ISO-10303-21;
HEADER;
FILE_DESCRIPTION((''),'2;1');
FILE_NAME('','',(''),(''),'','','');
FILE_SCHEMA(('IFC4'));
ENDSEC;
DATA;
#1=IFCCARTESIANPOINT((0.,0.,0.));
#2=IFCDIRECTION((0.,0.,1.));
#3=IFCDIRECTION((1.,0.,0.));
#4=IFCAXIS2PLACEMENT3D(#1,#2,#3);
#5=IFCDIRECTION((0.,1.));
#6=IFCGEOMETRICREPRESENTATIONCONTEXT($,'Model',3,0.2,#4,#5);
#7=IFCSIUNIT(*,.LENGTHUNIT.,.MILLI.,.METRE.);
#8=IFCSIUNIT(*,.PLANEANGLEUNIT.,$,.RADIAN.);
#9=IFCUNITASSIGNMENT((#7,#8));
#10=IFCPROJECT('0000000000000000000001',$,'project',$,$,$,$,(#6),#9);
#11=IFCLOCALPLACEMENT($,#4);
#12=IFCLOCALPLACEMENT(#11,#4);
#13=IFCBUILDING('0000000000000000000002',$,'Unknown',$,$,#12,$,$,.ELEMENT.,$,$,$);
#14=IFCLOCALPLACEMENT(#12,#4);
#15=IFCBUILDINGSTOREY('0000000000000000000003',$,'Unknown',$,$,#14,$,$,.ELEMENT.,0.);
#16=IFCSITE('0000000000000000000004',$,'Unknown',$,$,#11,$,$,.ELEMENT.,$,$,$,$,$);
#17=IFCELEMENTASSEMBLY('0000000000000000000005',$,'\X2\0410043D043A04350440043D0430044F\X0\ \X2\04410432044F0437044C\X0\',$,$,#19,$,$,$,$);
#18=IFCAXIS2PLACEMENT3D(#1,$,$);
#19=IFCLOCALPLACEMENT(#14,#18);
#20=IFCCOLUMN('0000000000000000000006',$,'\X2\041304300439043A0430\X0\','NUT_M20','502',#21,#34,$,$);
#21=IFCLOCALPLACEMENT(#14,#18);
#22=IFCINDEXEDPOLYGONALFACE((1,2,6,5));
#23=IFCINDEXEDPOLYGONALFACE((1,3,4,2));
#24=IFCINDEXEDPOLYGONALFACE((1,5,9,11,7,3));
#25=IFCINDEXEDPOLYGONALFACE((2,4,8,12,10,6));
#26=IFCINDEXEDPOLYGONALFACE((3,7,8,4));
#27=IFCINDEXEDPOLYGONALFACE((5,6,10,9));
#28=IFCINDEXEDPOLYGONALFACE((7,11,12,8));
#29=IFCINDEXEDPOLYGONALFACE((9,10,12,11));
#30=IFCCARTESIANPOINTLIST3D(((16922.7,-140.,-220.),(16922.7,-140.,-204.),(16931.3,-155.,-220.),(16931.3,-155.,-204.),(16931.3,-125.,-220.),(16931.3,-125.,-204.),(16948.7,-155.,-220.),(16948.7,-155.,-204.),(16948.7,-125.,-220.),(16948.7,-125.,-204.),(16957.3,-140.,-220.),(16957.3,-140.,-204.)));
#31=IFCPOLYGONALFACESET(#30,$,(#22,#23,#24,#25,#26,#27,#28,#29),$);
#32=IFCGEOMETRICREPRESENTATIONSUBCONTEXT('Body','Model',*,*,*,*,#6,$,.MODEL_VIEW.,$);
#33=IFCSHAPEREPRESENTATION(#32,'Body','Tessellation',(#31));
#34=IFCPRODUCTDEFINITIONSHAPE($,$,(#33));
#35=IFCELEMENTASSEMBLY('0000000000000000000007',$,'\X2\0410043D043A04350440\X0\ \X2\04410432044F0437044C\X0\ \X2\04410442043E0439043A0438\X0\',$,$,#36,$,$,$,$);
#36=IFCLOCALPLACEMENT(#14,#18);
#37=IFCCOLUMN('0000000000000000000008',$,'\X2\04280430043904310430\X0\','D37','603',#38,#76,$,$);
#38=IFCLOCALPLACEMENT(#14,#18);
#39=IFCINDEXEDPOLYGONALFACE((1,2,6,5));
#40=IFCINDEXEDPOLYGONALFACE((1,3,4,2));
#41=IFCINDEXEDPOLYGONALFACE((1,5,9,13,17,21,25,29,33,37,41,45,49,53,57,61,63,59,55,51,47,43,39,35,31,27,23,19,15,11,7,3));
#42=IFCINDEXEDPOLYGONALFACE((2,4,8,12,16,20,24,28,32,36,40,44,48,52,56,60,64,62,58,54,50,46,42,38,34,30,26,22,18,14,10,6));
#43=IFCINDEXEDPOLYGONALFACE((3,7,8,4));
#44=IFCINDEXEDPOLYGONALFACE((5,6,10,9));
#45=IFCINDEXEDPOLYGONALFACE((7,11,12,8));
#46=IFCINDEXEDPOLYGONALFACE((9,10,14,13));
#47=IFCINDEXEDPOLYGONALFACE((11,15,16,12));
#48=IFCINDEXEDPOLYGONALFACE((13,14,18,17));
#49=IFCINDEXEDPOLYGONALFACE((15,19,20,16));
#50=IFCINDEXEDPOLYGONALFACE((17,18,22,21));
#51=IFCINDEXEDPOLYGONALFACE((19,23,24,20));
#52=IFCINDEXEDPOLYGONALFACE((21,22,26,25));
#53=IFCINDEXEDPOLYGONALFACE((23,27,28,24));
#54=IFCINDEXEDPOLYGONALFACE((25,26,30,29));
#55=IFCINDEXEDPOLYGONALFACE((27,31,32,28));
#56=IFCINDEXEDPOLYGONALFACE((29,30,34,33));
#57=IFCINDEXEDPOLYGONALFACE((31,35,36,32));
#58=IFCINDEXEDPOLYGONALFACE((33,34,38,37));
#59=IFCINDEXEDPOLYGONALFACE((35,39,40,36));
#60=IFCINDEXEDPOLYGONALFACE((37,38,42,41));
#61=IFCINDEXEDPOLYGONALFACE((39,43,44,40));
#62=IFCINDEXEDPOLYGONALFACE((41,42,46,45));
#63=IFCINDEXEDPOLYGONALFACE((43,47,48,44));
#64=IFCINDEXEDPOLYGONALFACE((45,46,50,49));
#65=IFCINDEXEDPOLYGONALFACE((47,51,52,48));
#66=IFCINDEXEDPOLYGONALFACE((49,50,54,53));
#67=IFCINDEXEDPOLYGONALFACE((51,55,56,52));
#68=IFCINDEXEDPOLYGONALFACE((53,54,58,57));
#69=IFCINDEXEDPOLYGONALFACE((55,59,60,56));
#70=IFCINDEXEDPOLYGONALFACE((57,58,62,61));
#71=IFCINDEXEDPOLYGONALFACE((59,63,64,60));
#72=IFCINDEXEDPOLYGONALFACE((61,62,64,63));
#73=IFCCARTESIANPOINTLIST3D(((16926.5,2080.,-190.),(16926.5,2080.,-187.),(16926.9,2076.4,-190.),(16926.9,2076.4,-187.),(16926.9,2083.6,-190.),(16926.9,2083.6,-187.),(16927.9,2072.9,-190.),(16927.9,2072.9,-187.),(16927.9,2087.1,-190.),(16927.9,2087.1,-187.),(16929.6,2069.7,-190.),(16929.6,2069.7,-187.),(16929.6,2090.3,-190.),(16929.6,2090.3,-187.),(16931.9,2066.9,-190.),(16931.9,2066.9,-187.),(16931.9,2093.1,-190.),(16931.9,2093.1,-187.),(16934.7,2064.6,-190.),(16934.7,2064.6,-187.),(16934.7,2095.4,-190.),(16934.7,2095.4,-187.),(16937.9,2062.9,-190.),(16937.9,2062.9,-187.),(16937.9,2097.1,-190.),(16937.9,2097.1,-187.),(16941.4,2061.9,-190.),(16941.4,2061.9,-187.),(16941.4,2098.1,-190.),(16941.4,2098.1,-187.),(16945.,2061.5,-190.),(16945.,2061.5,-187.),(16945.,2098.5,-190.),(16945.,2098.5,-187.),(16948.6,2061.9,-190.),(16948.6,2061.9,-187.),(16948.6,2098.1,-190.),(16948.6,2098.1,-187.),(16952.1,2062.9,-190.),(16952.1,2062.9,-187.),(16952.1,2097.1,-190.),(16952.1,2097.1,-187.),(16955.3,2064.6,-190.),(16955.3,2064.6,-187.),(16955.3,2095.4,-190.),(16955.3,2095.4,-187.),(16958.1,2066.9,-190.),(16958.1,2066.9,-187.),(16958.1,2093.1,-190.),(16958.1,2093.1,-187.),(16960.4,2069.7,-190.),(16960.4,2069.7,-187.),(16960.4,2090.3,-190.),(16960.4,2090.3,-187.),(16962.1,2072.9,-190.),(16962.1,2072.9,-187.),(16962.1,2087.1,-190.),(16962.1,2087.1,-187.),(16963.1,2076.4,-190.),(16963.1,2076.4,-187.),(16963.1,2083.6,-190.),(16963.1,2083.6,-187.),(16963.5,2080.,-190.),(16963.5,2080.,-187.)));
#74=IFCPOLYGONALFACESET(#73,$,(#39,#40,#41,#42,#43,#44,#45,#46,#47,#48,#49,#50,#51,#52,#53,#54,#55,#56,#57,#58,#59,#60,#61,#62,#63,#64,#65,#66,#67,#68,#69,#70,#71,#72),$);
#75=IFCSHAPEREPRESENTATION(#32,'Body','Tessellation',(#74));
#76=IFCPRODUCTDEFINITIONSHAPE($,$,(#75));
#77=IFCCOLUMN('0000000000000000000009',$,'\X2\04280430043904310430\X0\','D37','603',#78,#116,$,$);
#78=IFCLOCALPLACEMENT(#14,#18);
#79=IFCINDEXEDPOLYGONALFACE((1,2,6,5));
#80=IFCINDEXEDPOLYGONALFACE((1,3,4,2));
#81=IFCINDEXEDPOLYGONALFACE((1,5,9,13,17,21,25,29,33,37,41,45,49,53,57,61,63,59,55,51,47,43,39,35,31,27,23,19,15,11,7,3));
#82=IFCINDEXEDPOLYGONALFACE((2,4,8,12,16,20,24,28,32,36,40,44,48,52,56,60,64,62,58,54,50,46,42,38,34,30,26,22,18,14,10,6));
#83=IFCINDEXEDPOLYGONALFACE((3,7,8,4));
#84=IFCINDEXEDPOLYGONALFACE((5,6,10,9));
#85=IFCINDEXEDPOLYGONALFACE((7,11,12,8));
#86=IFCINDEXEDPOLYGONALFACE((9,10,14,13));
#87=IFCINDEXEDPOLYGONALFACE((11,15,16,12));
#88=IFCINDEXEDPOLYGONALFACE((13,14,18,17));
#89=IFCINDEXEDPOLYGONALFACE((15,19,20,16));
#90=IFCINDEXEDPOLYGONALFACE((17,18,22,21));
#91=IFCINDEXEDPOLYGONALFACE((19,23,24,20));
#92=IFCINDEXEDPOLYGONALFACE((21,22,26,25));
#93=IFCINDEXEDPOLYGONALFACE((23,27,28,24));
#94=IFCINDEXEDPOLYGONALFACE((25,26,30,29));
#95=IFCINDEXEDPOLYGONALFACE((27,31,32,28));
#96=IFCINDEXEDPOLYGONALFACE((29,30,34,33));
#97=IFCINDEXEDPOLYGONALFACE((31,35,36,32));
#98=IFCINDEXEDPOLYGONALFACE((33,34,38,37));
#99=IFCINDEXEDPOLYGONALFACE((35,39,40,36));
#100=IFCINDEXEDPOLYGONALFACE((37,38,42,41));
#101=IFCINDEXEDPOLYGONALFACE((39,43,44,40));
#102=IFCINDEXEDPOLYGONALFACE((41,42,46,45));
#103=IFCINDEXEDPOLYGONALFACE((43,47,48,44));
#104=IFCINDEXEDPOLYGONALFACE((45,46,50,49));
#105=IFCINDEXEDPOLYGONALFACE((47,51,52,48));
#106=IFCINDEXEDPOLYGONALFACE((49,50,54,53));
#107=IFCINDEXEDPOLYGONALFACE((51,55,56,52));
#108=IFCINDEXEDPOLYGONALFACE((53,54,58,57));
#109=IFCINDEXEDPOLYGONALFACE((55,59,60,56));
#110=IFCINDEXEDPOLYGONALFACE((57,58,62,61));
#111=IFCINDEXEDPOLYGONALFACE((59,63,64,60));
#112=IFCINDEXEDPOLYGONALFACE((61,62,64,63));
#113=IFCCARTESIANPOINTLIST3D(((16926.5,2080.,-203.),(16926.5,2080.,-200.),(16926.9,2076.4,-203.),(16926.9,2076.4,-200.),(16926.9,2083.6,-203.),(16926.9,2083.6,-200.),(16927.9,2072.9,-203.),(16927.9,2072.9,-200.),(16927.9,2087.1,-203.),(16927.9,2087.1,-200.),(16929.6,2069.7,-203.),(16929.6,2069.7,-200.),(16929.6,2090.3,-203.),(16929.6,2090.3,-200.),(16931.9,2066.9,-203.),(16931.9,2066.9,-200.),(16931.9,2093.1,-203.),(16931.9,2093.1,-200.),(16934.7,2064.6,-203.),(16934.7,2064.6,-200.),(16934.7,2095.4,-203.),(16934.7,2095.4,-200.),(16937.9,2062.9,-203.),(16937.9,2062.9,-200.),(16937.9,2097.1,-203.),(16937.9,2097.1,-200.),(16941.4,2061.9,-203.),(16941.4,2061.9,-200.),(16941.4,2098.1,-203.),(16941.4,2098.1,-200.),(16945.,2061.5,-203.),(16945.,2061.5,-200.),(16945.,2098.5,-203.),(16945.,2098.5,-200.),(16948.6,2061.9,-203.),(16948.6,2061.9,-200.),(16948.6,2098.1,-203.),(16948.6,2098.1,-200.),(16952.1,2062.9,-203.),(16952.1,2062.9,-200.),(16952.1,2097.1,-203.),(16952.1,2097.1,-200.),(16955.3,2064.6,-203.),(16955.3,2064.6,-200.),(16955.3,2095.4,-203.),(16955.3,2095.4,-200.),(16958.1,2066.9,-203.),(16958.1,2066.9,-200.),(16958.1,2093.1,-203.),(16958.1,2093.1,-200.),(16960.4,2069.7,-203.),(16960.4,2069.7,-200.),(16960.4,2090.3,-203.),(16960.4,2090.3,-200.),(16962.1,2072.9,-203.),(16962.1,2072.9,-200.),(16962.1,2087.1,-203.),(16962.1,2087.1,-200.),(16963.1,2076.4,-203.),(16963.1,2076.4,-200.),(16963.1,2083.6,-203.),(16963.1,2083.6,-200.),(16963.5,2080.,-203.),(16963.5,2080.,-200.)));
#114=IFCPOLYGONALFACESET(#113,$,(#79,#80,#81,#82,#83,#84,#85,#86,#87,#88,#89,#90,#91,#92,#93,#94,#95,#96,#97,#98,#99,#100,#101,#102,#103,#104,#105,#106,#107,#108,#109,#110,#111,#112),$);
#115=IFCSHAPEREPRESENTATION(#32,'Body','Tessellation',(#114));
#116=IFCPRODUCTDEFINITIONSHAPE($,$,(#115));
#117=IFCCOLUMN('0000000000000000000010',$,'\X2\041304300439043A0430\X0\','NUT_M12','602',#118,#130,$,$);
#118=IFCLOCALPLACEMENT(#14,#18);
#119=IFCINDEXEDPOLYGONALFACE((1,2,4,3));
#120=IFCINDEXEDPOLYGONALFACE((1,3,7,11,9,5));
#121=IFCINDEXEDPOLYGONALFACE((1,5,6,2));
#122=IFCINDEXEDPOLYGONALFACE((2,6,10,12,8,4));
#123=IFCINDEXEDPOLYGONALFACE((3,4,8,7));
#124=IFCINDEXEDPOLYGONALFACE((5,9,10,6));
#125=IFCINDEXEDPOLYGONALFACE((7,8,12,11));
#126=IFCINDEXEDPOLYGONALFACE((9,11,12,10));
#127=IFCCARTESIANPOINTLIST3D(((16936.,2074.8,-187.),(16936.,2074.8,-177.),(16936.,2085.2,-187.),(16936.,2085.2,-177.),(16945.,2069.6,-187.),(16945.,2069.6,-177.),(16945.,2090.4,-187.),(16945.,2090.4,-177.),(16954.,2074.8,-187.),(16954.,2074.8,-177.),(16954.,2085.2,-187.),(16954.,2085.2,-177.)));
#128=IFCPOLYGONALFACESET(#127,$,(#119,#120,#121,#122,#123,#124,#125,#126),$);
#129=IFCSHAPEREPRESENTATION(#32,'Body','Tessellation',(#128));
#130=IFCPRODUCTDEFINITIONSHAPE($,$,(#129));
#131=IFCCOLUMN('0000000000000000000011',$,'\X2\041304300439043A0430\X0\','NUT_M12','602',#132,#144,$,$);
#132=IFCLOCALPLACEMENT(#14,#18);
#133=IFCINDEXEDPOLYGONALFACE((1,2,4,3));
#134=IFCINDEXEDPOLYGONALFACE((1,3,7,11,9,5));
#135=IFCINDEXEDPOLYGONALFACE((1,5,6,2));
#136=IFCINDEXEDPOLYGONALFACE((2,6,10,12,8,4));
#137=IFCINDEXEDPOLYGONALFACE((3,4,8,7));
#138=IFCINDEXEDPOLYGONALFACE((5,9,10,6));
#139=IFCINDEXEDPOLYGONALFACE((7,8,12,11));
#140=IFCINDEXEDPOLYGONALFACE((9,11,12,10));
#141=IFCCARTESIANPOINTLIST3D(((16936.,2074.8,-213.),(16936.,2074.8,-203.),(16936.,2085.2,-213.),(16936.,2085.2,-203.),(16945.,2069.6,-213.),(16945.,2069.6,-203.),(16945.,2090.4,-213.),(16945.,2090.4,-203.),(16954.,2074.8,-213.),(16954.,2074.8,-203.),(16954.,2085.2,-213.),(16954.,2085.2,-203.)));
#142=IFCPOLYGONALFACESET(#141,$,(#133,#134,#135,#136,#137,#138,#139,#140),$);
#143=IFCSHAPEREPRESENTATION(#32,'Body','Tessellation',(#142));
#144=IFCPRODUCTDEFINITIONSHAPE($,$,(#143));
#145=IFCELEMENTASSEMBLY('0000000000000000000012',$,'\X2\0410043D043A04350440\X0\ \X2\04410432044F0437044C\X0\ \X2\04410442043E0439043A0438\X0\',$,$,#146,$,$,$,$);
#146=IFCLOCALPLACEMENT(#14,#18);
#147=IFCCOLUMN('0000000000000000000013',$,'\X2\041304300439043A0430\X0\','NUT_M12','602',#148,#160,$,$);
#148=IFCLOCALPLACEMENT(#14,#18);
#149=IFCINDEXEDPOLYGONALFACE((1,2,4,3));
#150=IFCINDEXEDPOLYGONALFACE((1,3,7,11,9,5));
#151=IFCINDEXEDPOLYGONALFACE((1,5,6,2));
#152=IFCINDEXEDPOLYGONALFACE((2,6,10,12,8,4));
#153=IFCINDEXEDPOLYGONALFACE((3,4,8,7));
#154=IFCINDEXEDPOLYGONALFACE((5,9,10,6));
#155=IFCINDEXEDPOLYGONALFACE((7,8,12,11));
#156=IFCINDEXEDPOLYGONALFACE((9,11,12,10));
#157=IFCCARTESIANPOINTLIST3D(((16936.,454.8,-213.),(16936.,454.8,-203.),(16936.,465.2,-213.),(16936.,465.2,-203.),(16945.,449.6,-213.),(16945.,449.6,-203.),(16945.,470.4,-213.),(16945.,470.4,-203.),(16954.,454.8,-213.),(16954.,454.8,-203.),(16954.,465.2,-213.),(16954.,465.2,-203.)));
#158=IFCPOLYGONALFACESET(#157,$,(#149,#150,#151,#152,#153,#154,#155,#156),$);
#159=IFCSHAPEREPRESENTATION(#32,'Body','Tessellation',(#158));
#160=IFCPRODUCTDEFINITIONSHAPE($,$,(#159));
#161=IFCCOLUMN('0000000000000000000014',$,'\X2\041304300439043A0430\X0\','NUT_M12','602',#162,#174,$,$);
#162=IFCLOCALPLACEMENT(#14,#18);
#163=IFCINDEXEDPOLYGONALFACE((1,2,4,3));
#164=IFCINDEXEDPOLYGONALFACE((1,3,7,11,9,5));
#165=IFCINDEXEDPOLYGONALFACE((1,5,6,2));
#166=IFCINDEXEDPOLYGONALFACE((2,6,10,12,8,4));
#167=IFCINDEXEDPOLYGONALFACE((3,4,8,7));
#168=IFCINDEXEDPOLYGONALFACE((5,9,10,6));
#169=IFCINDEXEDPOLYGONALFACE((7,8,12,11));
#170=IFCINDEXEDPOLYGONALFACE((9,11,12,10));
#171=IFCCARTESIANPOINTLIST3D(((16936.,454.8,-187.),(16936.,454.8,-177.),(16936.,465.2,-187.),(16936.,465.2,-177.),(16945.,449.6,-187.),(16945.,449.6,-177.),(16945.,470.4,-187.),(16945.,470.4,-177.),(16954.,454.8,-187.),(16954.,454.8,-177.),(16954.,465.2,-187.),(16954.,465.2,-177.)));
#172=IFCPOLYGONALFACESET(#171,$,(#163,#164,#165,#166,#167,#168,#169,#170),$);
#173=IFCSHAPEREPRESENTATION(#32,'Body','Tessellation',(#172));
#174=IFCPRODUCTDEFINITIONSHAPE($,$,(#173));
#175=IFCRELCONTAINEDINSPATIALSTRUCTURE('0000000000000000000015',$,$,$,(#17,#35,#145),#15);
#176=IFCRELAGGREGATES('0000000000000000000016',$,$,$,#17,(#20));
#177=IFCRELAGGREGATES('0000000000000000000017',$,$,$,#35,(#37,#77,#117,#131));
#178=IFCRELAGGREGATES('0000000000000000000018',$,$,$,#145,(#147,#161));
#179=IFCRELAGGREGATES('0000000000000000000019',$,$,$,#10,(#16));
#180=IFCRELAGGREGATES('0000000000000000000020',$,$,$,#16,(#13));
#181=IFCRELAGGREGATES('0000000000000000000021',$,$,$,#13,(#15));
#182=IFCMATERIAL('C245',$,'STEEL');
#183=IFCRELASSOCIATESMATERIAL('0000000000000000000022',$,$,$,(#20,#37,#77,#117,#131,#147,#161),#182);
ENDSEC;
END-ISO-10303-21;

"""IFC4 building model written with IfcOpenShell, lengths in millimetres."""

from ifc_helpers import new_model, si_unit, direction, frame, origin_with_axes, place, context, subcontext, project, spatial, line, indexed_curve, outline, extrude, material, element, aggregate, save


model = new_model("IFC4")

# Units and contexts
model_context = context("Model", 3, precision=0.2, world=origin_with_axes(), true_north=direction((0.0, 1.0)))
body_context = subcontext(model_context, "Body", "Model", "MODEL_VIEW")
ifc_project = project(units=[si_unit("LENGTHUNIT", "METRE", prefix="MILLI"), si_unit("PLANEANGLEUNIT", "RADIAN")], contexts=[model_context])

# Site, building, storey
site_placement = place(None, origin_with_axes())
site = spatial("IfcSite", under=ifc_project, at=site_placement, Name="Unknown", CompositionType="ELEMENT")
building_placement = place(site_placement, origin_with_axes())
building = spatial("IfcBuilding", under=site, at=building_placement, Name="Unknown", CompositionType="ELEMENT")
storey_placement = place(building_placement, origin_with_axes())
storey = spatial("IfcBuildingStorey", under=building, at=storey_placement, Name="Unknown", CompositionType="ELEMENT", Elevation=0.0)

# Element assemblies, columns
ifc_material_1 = material(Name="C245", Category="STEEL")
assembly_1_placement = place(storey_placement, frame((16940.0, -140.0, -125.0), z_axis=(1.0, 0.0, 0.0), x_axis=(0.0, 0.0, -1.0)))
assembly_1 = element("IfcElementAssembly", 1, at=assembly_1_placement, inside=storey, Name="Анкерная связь")
column_1_placement = place(assembly_1_placement, frame((79.0, 0.0, 0.0), z_axis=(0.0, 0.0, 1.0), x_axis=(1.0, 0.0, 0.0)))
column_1 = element("IfcColumn", 2, at=column_1_placement, material=ifc_material_1, Name="Гайка", Description="NUT_M20", ObjectType="502", context=body_context, shape_type="SolidModel", body=[
    extrude(outline(indexed_curve([(8.7, -15.0), (17.3, 0.0), (8.7, 15.0), (-8.7, 15.0), (-17.3, 0.0), (-8.7, -15.0)], segments=[line(1, 2, 3, 4, 5, 6, 1)])), frame((0.0, 0.0, 0.0), z_axis=(-1.0, 0.0, 0.0), x_axis=(0.0, 0.0, 1.0)), (0.0, 0.0, -1.0), 16.0),
])
assembly_2_placement = place(storey_placement, frame((16945.0, 2080.0, -160.0), z_axis=(0.0, -1.0, 0.0), x_axis=(0.0, 0.0, -1.0)))
assembly_2 = element("IfcElementAssembly", 3, at=assembly_2_placement, inside=storey, Name="Анкер связь стойки")
column_2_placement = place(assembly_2_placement, frame((27.0, 0.0, 0.0), z_axis=(0.0, 0.0, 1.0), x_axis=(1.0, 0.0, 0.0)))
column_2 = element("IfcColumn", 4, at=column_2_placement, material=ifc_material_1, Name="Шайба", Description="D37", ObjectType="603", context=body_context, shape_type="SolidModel", body=[
    extrude(outline(indexed_curve([(18.5, 0.0), (18.1, 3.6), (17.1, 7.1), (15.4, 10.3), (13.1, 13.1), (10.3, 15.4), (7.1, 17.1), (3.6, 18.1), (0.0, 18.5), (-3.6, 18.1), (-7.1, 17.1), (-10.3, 15.4), (-13.1, 13.1), (-15.4, 10.3), (-17.1, 7.1), (-18.1, 3.6), (-18.5, 0.0), (-18.1, -3.6), (-17.1, -7.1), (-15.4, -10.3), (-13.1, -13.1), (-10.3, -15.4), (-7.1, -17.1), (-3.6, -18.1), (0.0, -18.5), (3.6, -18.1), (7.1, -17.1), (10.3, -15.4), (13.1, -13.1), (15.4, -10.3), (17.1, -7.1), (18.1, -3.6)], segments=[line(1, 2, 3, 4, 5, 6, 7, 8, 9, 10, 11, 12, 13, 14, 15, 16, 17, 18, 19, 20, 21, 22, 23, 24, 25, 26, 27, 28, 29, 30, 31, 32, 1)])), frame((0.0, 0.0, 0.0), z_axis=(-1.0, 0.0, 0.0), x_axis=(0.0, 0.0, 1.0)), (0.0, 0.0, -1.0), 3.0),
])
column_3_placement = place(assembly_2_placement, frame((40.0, 0.0, 0.0), z_axis=(0.0, -1.0, 0.0), x_axis=(1.0, 0.0, 0.0)))
column_3 = element("IfcColumn", 5, at=column_3_placement, material=ifc_material_1, Name="Шайба", Description="D37", ObjectType="603", context=body_context, shape_type="SolidModel", body=[
    extrude(outline(indexed_curve([(18.5, 0.0), (18.1, 3.6), (17.1, 7.1), (15.4, 10.3), (13.1, 13.1), (10.3, 15.4), (7.1, 17.1), (3.6, 18.1), (0.0, 18.5), (-3.6, 18.1), (-7.1, 17.1), (-10.3, 15.4), (-13.1, 13.1), (-15.4, 10.3), (-17.1, 7.1), (-18.1, 3.6), (-18.5, 0.0), (-18.1, -3.6), (-17.1, -7.1), (-15.4, -10.3), (-13.1, -13.1), (-10.3, -15.4), (-7.1, -17.1), (-3.6, -18.1), (0.0, -18.5), (3.6, -18.1), (7.1, -17.1), (10.3, -15.4), (13.1, -13.1), (15.4, -10.3), (17.1, -7.1), (18.1, -3.6)], segments=[line(1, 2, 3, 4, 5, 6, 7, 8, 9, 10, 11, 12, 13, 14, 15, 16, 17, 18, 19, 20, 21, 22, 23, 24, 25, 26, 27, 28, 29, 30, 31, 32, 1)])), frame((0.0, 0.0, 0.0), z_axis=(-1.0, 0.0, 0.0), x_axis=(0.0, 0.0, 1.0)), (0.0, 0.0, -1.0), 3.0),
])
column_4_placement = place(assembly_2_placement, frame((17.0, 0.0, 0.0), z_axis=(0.0, 0.0, 1.0), x_axis=(1.0, 0.0, 0.0)))
column_4 = element("IfcColumn", 6, at=column_4_placement, material=ifc_material_1, Name="Гайка", Description="NUT_M12", ObjectType="602", context=body_context, shape_type="SolidModel", body=[
    extrude(outline(indexed_curve([(5.2, -9.0), (10.4, 0.0), (5.2, 9.0), (-5.2, 9.0), (-10.4, 0.0), (-5.2, -9.0)], segments=[line(1, 2, 3, 4, 5, 6, 1)])), frame((0.0, 0.0, 0.0), z_axis=(-1.0, 0.0, 0.0), x_axis=(0.0, 0.0, 1.0)), (0.0, 0.0, -1.0), 10.0),
])
column_5_placement = place(assembly_2_placement, frame((43.0, 0.0, 0.0), z_axis=(0.0, 0.0, 1.0), x_axis=(1.0, 0.0, 0.0)))
column_5 = element("IfcColumn", 7, at=column_5_placement, material=ifc_material_1, Name="Гайка", Description="NUT_M12", ObjectType="602", context=body_context, shape_type="SolidModel", body=[
    extrude(outline(indexed_curve([(5.2, -9.0), (10.4, 0.0), (5.2, 9.0), (-5.2, 9.0), (-10.4, 0.0), (-5.2, -9.0)], segments=[line(1, 2, 3, 4, 5, 6, 1)])), frame((0.0, 0.0, 0.0), z_axis=(-1.0, 0.0, 0.0), x_axis=(0.0, 0.0, 1.0)), (0.0, 0.0, -1.0), 10.0),
])
assembly_3_placement = place(storey_placement, frame((16945.0, 460.0, -160.0), z_axis=(0.0, -1.0, 0.0), x_axis=(0.0, 0.0, -1.0)))
assembly_3 = element("IfcElementAssembly", 8, at=assembly_3_placement, inside=storey, Name="Анкер связь стойки")
column_6_placement = place(assembly_3_placement, frame((43.0, 0.0, 0.0), z_axis=(0.0, 0.0, 1.0), x_axis=(1.0, 0.0, 0.0)))
column_6 = element("IfcColumn", 9, at=column_6_placement, material=ifc_material_1, Name="Гайка", Description="NUT_M12", ObjectType="602", context=body_context, shape_type="SolidModel", body=[
    extrude(outline(indexed_curve([(5.2, -9.0), (10.4, 0.0), (5.2, 9.0), (-5.2, 9.0), (-10.4, 0.0), (-5.2, -9.0)], segments=[line(1, 2, 3, 4, 5, 6, 1)])), frame((0.0, 0.0, 0.0), z_axis=(-1.0, 0.0, 0.0), x_axis=(0.0, 0.0, 1.0)), (0.0, 0.0, -1.0), 10.0),
])
column_7_placement = place(assembly_3_placement, frame((17.0, 0.0, 0.0), z_axis=(0.0, 0.0, 1.0), x_axis=(1.0, 0.0, 0.0)))
column_7 = element("IfcColumn", 10, at=column_7_placement, material=ifc_material_1, Name="Гайка", Description="NUT_M12", ObjectType="602", context=body_context, shape_type="SolidModel", body=[
    extrude(outline(indexed_curve([(5.2, -9.0), (10.4, 0.0), (5.2, 9.0), (-5.2, 9.0), (-10.4, 0.0), (-5.2, -9.0)], segments=[line(1, 2, 3, 4, 5, 6, 1)])), frame((0.0, 0.0, 0.0), z_axis=(-1.0, 0.0, 0.0), x_axis=(0.0, 0.0, 1.0)), (0.0, 0.0, -1.0), 10.0),
])

aggregate(assembly_1, [column_1])
aggregate(assembly_2, [column_2, column_3, column_4, column_5])
aggregate(assembly_3, [column_6, column_7])

save(model, "model.ifc")
